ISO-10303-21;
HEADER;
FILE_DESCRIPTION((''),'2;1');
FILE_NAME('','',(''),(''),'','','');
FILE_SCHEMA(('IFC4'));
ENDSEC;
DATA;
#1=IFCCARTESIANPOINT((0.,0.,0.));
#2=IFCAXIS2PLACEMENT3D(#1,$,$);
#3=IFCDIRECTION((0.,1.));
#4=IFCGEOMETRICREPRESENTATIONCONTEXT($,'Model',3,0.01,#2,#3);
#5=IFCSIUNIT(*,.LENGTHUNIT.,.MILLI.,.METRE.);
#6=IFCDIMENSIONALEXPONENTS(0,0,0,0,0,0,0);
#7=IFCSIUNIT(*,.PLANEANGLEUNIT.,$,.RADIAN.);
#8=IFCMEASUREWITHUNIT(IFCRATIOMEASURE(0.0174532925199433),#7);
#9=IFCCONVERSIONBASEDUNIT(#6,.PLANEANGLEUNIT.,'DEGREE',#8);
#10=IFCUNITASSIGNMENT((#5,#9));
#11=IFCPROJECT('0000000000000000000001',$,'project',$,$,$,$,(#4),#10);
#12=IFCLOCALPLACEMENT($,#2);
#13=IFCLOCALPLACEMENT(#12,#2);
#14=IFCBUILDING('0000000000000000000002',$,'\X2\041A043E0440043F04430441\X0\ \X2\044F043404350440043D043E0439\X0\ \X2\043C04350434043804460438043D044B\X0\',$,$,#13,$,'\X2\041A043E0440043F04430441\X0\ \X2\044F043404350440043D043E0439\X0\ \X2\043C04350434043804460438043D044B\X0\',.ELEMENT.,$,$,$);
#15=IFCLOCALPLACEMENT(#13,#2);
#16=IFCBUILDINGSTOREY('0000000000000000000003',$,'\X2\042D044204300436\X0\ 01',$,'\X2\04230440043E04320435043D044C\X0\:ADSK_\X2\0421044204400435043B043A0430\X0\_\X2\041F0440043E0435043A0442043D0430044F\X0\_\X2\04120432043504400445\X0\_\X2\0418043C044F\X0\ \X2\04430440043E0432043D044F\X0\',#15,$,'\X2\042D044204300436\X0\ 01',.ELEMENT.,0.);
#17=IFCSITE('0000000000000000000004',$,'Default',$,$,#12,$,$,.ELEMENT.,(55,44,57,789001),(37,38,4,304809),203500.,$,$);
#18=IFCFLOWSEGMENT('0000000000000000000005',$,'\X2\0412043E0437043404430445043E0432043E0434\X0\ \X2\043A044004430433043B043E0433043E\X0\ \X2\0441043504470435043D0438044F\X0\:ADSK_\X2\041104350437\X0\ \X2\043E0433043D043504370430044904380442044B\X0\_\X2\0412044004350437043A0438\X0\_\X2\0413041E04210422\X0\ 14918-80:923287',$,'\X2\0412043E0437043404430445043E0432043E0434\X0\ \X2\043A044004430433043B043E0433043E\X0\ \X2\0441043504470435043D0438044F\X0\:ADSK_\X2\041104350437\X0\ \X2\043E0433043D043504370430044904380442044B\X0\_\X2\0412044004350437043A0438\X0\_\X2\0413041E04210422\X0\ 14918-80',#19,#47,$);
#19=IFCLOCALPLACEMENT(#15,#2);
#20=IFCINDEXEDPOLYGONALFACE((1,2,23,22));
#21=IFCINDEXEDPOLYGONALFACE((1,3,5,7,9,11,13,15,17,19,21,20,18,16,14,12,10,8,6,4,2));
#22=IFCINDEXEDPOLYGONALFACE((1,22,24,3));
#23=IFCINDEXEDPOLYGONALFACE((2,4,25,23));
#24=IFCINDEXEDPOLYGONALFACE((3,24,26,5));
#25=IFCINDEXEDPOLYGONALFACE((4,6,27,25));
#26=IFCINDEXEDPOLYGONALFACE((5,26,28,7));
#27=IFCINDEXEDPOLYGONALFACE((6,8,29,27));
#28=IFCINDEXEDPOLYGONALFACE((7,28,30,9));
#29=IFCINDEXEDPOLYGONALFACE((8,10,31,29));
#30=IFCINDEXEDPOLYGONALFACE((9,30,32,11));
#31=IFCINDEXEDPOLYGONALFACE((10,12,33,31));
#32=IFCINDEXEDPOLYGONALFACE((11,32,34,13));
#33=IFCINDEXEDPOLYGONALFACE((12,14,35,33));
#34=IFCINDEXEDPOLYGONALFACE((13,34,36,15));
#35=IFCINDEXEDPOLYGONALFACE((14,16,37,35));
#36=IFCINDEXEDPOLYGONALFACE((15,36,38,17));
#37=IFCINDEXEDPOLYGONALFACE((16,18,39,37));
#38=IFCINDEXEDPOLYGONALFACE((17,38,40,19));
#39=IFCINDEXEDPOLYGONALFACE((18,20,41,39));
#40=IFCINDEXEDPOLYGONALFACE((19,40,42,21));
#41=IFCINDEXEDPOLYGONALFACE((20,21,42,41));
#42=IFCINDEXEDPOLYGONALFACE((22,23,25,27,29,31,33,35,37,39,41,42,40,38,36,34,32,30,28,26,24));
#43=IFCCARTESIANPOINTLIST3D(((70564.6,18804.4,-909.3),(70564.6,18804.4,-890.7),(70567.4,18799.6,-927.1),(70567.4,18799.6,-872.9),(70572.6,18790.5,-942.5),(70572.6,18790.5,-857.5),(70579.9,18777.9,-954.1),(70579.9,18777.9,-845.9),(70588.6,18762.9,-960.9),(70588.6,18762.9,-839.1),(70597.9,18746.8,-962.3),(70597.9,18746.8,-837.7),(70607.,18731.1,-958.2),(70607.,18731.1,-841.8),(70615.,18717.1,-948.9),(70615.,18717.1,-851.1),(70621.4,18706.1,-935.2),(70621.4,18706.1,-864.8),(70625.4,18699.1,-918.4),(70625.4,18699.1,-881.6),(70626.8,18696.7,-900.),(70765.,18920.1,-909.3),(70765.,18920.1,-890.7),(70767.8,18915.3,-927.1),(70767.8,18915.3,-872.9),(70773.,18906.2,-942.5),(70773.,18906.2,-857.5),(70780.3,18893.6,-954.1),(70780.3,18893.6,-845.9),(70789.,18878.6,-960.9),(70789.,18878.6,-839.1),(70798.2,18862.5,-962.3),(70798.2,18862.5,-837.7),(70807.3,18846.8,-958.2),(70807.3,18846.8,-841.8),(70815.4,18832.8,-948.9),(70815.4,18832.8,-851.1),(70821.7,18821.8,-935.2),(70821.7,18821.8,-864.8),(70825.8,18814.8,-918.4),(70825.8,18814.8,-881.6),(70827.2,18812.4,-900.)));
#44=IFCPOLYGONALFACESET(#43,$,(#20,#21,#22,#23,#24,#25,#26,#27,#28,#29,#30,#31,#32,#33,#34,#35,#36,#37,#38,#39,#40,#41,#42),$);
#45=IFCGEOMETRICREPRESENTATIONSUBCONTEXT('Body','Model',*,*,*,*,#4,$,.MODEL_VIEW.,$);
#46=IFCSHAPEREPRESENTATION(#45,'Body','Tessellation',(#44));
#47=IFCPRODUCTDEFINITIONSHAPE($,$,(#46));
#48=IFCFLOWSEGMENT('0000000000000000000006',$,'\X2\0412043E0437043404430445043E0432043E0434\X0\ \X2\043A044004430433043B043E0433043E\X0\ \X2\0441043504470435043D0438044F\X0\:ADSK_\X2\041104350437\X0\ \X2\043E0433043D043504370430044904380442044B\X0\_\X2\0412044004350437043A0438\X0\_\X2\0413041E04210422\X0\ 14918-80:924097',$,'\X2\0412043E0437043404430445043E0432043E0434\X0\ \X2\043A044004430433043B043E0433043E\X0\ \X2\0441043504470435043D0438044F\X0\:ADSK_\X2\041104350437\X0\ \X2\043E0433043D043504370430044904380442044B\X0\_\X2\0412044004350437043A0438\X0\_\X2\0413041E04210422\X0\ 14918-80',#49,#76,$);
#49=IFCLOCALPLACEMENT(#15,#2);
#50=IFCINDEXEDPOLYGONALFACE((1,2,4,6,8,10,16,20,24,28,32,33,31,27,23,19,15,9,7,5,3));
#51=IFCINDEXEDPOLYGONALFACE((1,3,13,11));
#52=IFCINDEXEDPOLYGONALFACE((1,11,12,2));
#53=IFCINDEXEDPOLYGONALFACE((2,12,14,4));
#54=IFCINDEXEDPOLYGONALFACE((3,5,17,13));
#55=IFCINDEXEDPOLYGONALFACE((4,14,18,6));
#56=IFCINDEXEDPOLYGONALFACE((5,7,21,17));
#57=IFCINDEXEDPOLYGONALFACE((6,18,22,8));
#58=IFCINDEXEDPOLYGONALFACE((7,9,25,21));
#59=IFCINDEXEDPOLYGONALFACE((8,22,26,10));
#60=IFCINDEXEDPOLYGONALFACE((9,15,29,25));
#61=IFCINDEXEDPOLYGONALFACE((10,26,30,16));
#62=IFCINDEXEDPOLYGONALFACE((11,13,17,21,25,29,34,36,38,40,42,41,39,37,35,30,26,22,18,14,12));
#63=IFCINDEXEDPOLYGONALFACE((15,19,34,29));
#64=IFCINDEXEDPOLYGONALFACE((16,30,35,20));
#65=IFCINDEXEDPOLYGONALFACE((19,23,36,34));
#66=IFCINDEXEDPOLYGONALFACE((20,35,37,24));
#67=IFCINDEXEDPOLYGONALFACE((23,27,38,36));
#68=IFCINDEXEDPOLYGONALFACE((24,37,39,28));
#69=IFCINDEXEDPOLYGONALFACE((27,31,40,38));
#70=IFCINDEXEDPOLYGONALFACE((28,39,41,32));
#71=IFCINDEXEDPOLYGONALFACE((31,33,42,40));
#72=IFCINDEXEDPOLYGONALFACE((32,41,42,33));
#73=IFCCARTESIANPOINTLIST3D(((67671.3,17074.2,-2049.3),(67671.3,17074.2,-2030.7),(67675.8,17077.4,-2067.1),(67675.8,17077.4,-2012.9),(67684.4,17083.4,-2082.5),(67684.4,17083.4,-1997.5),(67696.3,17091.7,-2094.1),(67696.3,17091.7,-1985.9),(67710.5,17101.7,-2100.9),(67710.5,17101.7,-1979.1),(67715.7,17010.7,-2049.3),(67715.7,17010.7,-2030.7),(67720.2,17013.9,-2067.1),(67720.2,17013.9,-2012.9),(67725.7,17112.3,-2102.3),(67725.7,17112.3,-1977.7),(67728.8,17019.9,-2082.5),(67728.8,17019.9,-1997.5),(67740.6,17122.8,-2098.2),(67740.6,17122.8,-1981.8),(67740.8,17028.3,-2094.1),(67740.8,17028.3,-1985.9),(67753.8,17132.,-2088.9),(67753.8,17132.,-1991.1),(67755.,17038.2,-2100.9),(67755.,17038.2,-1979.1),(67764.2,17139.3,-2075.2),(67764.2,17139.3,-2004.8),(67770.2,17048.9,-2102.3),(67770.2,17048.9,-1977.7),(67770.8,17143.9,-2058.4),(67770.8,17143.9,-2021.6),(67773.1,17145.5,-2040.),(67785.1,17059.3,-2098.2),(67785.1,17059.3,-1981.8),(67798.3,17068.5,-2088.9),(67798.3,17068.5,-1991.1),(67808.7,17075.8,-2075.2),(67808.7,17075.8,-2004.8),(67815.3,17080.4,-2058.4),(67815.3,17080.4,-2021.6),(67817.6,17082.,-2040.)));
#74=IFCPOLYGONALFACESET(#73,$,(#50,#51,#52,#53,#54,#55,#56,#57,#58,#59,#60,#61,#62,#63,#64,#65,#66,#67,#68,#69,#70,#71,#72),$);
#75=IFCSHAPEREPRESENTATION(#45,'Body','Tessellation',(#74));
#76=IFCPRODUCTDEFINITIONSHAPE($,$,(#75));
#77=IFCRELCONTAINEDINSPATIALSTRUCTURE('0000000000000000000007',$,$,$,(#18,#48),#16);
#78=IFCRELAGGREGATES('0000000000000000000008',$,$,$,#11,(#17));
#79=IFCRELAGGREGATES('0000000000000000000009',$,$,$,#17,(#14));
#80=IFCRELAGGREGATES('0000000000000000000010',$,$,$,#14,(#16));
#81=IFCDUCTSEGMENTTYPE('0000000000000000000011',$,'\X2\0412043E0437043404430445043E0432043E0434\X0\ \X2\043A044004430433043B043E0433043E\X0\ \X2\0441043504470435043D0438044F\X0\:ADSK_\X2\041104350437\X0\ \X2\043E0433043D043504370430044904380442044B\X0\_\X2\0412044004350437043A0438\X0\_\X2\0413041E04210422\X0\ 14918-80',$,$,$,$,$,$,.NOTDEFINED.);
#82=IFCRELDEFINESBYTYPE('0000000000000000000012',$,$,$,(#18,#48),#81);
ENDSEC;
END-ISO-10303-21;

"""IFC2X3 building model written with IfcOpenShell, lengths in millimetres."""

from ifc_helpers import new_model, entity, si_unit, converted_unit, direction, frame, origin, origin_2d_with_axis, place, context, subcontext, project, spatial, circle, extrude, type_object, element, save


model = new_model("IFC2X3")

# Units and contexts
model_context = context("Model", 3, precision=0.01, world=origin(), true_north=direction((0.0, 1.0)))
body_context = subcontext(model_context, "Body", "Model", "MODEL_VIEW")
ifc_project = project(units=[si_unit("LENGTHUNIT", "METRE", prefix="MILLI"), converted_unit("PLANEANGLEUNIT", "DEGREE", entity("IfcRatioMeasure", 0.0174532925199433), si_unit("PLANEANGLEUNIT", "RADIAN"), dimensions=[0, 0, 0, 0, 0, 0, 0])], contexts=[model_context])

# Site, building, storey
site_placement = place(None, origin())
site = spatial("IfcSite", under=ifc_project, at=site_placement, Name="Default", CompositionType="ELEMENT", RefLatitude=(55, 44, 57, 789001), RefLongitude=(37, 38, 4, 304809), RefElevation=203500.0)
building_placement = place(site_placement, origin())
building = spatial("IfcBuilding", under=site, at=building_placement, Name="Корпус ядерной медицины", LongName="Корпус ядерной медицины", CompositionType="ELEMENT")
storey_placement = place(building_placement, origin())
storey = spatial("IfcBuildingStorey", under=building, at=storey_placement, Name="Этаж 01", ObjectType="Уровень:ADSK_Стрелка_Проектная_Вверх_Имя уровня", LongName="Этаж 01", CompositionType="ELEMENT", Elevation=0.0)

# Flow segments
duct_segment_type = type_object("IfcDuctSegmentType", Name="Воздуховод круглого сечения:ADSK_Без огнезащиты_Врезки_ГОСТ 14918-80", PredefinedType="NOTDEFINED")
flow_segment_1_placement = place(storey_placement, frame((70562.7, 18695.2, -964.1)))
element("IfcFlowSegment", 1, at=flow_segment_1_placement, inside=storey, type_object=duct_segment_type, Name="Воздуховод круглого сечения:ADSK_Без огнезащиты_Врезки_ГОСТ 14918-80:923287", ObjectType="Воздуховод круглого сечения:ADSK_Без огнезащиты_Врезки_ГОСТ 14918-80", context=body_context, shape_type="SweptSolid", body=[
    extrude(circle(Radius=62.5, at=origin_2d_with_axis()), frame((32.9, 55.7, 64.1), z_axis=(0.866025, 0.5, 0.0), x_axis=(0.5, -0.866025, 0.0)), (0.0, 0.0, 1.0), 231.4),
])
flow_segment_2_placement = place(storey_placement, frame((67669.1, 17008.7, -2104.1)))
element("IfcFlowSegment", 2, at=flow_segment_2_placement, inside=storey, type_object=duct_segment_type, Name="Воздуховод круглого сечения:ADSK_Без огнезащиты_Врезки_ГОСТ 14918-80:924097", ObjectType="Воздуховод круглого сечения:ADSK_Без огнезащиты_Врезки_ГОСТ 14918-80", context=body_context, shape_type="SweptSolid", body=[
    extrude(circle(Radius=62.5, at=origin_2d_with_axis()), frame((52.8, 100.9, 64.1), z_axis=(0.573576, -0.819152, 0.0), x_axis=(0.819152, 0.573576, 0.0)), (0.0, 0.0, 1.0), 77.5),
])

save(model, "model.ifc")
